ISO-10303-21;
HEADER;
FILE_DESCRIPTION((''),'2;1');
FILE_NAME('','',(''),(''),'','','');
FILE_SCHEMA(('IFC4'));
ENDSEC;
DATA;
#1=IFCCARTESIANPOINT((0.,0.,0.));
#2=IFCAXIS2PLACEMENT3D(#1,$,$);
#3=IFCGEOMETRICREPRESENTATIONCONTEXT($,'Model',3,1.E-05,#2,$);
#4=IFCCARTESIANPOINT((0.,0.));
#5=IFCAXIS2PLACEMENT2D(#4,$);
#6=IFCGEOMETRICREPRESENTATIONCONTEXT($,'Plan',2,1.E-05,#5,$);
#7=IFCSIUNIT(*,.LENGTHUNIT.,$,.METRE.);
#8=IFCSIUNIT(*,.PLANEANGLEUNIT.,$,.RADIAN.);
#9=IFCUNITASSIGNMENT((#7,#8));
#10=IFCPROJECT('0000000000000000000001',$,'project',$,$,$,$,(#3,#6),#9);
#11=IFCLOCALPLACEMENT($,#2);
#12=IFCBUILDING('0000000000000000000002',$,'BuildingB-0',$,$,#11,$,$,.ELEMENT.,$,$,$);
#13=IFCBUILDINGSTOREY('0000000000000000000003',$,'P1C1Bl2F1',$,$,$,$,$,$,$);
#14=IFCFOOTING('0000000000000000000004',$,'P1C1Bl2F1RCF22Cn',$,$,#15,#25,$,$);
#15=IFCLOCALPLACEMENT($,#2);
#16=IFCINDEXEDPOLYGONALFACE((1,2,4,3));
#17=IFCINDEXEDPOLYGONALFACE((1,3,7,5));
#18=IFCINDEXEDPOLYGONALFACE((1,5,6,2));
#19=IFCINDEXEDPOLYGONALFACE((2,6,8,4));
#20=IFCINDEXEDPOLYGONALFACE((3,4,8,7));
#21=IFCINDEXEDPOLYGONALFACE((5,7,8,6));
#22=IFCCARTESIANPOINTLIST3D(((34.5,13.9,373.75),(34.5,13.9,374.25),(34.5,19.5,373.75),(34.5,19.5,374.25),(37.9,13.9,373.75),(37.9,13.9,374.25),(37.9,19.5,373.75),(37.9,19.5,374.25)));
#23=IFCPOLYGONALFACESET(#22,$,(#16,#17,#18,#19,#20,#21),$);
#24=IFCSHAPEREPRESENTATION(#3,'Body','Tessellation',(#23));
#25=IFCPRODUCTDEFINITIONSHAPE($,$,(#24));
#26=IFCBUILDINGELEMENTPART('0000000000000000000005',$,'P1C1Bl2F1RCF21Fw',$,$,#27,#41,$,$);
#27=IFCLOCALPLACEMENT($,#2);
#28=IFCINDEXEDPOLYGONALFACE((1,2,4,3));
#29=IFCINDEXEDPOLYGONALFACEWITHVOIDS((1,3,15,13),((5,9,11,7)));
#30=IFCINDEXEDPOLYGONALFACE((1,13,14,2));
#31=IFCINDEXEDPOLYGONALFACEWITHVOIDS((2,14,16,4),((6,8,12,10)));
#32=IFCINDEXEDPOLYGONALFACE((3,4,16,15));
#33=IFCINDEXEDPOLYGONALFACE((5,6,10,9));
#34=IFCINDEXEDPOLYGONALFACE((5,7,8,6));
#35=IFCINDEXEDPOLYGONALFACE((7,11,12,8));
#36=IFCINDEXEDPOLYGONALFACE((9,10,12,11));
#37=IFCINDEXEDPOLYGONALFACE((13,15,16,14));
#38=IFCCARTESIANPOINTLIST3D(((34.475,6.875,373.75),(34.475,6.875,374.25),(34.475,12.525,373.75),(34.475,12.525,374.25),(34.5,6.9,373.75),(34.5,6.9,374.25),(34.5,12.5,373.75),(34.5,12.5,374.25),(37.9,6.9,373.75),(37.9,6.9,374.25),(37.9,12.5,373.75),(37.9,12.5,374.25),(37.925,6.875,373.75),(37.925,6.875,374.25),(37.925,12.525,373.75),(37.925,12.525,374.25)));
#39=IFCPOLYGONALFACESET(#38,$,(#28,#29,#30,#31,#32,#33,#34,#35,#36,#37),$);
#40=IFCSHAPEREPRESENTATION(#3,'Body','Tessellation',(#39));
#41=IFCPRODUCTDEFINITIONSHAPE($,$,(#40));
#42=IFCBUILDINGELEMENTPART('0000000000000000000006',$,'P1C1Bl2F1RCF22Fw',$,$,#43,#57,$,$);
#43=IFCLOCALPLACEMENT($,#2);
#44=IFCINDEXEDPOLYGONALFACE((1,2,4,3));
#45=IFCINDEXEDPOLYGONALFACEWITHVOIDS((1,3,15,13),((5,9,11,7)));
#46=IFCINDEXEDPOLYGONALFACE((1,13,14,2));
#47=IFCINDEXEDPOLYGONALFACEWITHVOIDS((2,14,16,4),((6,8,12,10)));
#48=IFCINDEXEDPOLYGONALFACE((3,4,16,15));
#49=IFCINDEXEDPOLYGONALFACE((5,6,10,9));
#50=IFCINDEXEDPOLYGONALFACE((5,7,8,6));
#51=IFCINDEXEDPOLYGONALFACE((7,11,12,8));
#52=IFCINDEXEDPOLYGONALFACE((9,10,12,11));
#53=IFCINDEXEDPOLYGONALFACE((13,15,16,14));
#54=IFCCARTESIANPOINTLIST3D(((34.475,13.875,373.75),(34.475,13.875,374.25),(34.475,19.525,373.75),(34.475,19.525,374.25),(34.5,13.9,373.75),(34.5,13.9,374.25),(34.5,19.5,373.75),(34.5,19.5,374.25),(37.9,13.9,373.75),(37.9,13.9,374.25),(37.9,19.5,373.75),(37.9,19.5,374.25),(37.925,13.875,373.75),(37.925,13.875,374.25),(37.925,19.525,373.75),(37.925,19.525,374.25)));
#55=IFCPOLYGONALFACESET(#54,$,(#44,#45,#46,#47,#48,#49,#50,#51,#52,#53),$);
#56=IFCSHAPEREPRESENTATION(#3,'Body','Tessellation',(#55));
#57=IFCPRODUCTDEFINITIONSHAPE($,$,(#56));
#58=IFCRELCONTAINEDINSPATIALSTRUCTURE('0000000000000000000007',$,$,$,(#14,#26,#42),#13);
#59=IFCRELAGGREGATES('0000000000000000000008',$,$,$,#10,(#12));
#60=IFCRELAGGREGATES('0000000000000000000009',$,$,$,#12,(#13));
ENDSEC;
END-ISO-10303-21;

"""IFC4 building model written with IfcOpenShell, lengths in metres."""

from ifc_helpers import new_model, si_unit, origin, origin_2d, place, context, project, spatial, polyline, outline, extrude, element, save


model = new_model("IFC4")

# Units and contexts
model_context = context("Model", 3, precision=1e-05, world=origin())
plan_context = context("Plan", 2, precision=1e-05, world=origin_2d())
ifc_project = project(units=[si_unit("LENGTHUNIT", "METRE"), si_unit("PLANEANGLEUNIT", "RADIAN")], contexts=[model_context, plan_context])

# Building, storey
building_placement = place(None, origin())
building = spatial("IfcBuilding", under=ifc_project, at=building_placement, Name="BuildingB-0", CompositionType="ELEMENT")
storey = spatial("IfcBuildingStorey", under=building, Name="P1C1Bl2F1")

# Footing
element("IfcFooting", 1, inside=storey, Name="P1C1Bl2F1RCF22Cn", context=model_context, shape_type="SweptSolid", body=[
    extrude(outline(polyline([(37.9, 19.5, 373.75), (34.5, 19.5, 373.75), (34.5, 13.9, 373.75), (37.9, 13.9, 373.75), (37.9, 19.5, 373.75)])), None, (0.0, 0.0, 1.0), 0.5),
])

# Building element part, opening
building_element_part_1 = element("IfcBuildingElementPart", 2, inside=storey, Name="P1C1Bl2F1RCF21Fw", context=model_context, shape_type="SweptSolid", body=[
    extrude(outline(polyline([(37.925, 12.525, 373.75), (34.475, 12.525, 373.75), (34.475, 6.875, 373.75), (37.925, 6.875, 373.75), (37.925, 12.525, 373.75)])), None, (0.0, 0.0, 1.0), 0.5),
])
element("IfcOpeningElement", 3, inside=storey, cuts=building_element_part_1, context=model_context, shape_type="SweptSolid", body=[
    extrude(outline(polyline([(37.9, 12.5, 373.75), (34.5, 12.5, 373.75), (34.5, 6.9, 373.75), (37.9, 6.9, 373.75), (37.9, 12.5, 373.75)])), None, (0.0, 0.0, 1.0), 0.5),
])

# Building element part, opening
building_element_part_2 = element("IfcBuildingElementPart", 4, inside=storey, Name="P1C1Bl2F1RCF22Fw", context=model_context, shape_type="SweptSolid", body=[
    extrude(outline(polyline([(37.925, 19.525, 373.75), (34.475, 19.525, 373.75), (34.475, 13.875, 373.75), (37.925, 13.875, 373.75), (37.925, 19.525, 373.75)])), None, (0.0, 0.0, 1.0), 0.5),
])
element("IfcOpeningElement", 5, inside=storey, cuts=building_element_part_2, context=model_context, shape_type="SweptSolid", body=[
    extrude(outline(polyline([(37.9, 19.5, 373.75), (34.5, 19.5, 373.75), (34.5, 13.9, 373.75), (37.9, 13.9, 373.75), (37.9, 19.5, 373.75)])), None, (0.0, 0.0, 1.0), 0.5),
])

save(model, "model.ifc")
